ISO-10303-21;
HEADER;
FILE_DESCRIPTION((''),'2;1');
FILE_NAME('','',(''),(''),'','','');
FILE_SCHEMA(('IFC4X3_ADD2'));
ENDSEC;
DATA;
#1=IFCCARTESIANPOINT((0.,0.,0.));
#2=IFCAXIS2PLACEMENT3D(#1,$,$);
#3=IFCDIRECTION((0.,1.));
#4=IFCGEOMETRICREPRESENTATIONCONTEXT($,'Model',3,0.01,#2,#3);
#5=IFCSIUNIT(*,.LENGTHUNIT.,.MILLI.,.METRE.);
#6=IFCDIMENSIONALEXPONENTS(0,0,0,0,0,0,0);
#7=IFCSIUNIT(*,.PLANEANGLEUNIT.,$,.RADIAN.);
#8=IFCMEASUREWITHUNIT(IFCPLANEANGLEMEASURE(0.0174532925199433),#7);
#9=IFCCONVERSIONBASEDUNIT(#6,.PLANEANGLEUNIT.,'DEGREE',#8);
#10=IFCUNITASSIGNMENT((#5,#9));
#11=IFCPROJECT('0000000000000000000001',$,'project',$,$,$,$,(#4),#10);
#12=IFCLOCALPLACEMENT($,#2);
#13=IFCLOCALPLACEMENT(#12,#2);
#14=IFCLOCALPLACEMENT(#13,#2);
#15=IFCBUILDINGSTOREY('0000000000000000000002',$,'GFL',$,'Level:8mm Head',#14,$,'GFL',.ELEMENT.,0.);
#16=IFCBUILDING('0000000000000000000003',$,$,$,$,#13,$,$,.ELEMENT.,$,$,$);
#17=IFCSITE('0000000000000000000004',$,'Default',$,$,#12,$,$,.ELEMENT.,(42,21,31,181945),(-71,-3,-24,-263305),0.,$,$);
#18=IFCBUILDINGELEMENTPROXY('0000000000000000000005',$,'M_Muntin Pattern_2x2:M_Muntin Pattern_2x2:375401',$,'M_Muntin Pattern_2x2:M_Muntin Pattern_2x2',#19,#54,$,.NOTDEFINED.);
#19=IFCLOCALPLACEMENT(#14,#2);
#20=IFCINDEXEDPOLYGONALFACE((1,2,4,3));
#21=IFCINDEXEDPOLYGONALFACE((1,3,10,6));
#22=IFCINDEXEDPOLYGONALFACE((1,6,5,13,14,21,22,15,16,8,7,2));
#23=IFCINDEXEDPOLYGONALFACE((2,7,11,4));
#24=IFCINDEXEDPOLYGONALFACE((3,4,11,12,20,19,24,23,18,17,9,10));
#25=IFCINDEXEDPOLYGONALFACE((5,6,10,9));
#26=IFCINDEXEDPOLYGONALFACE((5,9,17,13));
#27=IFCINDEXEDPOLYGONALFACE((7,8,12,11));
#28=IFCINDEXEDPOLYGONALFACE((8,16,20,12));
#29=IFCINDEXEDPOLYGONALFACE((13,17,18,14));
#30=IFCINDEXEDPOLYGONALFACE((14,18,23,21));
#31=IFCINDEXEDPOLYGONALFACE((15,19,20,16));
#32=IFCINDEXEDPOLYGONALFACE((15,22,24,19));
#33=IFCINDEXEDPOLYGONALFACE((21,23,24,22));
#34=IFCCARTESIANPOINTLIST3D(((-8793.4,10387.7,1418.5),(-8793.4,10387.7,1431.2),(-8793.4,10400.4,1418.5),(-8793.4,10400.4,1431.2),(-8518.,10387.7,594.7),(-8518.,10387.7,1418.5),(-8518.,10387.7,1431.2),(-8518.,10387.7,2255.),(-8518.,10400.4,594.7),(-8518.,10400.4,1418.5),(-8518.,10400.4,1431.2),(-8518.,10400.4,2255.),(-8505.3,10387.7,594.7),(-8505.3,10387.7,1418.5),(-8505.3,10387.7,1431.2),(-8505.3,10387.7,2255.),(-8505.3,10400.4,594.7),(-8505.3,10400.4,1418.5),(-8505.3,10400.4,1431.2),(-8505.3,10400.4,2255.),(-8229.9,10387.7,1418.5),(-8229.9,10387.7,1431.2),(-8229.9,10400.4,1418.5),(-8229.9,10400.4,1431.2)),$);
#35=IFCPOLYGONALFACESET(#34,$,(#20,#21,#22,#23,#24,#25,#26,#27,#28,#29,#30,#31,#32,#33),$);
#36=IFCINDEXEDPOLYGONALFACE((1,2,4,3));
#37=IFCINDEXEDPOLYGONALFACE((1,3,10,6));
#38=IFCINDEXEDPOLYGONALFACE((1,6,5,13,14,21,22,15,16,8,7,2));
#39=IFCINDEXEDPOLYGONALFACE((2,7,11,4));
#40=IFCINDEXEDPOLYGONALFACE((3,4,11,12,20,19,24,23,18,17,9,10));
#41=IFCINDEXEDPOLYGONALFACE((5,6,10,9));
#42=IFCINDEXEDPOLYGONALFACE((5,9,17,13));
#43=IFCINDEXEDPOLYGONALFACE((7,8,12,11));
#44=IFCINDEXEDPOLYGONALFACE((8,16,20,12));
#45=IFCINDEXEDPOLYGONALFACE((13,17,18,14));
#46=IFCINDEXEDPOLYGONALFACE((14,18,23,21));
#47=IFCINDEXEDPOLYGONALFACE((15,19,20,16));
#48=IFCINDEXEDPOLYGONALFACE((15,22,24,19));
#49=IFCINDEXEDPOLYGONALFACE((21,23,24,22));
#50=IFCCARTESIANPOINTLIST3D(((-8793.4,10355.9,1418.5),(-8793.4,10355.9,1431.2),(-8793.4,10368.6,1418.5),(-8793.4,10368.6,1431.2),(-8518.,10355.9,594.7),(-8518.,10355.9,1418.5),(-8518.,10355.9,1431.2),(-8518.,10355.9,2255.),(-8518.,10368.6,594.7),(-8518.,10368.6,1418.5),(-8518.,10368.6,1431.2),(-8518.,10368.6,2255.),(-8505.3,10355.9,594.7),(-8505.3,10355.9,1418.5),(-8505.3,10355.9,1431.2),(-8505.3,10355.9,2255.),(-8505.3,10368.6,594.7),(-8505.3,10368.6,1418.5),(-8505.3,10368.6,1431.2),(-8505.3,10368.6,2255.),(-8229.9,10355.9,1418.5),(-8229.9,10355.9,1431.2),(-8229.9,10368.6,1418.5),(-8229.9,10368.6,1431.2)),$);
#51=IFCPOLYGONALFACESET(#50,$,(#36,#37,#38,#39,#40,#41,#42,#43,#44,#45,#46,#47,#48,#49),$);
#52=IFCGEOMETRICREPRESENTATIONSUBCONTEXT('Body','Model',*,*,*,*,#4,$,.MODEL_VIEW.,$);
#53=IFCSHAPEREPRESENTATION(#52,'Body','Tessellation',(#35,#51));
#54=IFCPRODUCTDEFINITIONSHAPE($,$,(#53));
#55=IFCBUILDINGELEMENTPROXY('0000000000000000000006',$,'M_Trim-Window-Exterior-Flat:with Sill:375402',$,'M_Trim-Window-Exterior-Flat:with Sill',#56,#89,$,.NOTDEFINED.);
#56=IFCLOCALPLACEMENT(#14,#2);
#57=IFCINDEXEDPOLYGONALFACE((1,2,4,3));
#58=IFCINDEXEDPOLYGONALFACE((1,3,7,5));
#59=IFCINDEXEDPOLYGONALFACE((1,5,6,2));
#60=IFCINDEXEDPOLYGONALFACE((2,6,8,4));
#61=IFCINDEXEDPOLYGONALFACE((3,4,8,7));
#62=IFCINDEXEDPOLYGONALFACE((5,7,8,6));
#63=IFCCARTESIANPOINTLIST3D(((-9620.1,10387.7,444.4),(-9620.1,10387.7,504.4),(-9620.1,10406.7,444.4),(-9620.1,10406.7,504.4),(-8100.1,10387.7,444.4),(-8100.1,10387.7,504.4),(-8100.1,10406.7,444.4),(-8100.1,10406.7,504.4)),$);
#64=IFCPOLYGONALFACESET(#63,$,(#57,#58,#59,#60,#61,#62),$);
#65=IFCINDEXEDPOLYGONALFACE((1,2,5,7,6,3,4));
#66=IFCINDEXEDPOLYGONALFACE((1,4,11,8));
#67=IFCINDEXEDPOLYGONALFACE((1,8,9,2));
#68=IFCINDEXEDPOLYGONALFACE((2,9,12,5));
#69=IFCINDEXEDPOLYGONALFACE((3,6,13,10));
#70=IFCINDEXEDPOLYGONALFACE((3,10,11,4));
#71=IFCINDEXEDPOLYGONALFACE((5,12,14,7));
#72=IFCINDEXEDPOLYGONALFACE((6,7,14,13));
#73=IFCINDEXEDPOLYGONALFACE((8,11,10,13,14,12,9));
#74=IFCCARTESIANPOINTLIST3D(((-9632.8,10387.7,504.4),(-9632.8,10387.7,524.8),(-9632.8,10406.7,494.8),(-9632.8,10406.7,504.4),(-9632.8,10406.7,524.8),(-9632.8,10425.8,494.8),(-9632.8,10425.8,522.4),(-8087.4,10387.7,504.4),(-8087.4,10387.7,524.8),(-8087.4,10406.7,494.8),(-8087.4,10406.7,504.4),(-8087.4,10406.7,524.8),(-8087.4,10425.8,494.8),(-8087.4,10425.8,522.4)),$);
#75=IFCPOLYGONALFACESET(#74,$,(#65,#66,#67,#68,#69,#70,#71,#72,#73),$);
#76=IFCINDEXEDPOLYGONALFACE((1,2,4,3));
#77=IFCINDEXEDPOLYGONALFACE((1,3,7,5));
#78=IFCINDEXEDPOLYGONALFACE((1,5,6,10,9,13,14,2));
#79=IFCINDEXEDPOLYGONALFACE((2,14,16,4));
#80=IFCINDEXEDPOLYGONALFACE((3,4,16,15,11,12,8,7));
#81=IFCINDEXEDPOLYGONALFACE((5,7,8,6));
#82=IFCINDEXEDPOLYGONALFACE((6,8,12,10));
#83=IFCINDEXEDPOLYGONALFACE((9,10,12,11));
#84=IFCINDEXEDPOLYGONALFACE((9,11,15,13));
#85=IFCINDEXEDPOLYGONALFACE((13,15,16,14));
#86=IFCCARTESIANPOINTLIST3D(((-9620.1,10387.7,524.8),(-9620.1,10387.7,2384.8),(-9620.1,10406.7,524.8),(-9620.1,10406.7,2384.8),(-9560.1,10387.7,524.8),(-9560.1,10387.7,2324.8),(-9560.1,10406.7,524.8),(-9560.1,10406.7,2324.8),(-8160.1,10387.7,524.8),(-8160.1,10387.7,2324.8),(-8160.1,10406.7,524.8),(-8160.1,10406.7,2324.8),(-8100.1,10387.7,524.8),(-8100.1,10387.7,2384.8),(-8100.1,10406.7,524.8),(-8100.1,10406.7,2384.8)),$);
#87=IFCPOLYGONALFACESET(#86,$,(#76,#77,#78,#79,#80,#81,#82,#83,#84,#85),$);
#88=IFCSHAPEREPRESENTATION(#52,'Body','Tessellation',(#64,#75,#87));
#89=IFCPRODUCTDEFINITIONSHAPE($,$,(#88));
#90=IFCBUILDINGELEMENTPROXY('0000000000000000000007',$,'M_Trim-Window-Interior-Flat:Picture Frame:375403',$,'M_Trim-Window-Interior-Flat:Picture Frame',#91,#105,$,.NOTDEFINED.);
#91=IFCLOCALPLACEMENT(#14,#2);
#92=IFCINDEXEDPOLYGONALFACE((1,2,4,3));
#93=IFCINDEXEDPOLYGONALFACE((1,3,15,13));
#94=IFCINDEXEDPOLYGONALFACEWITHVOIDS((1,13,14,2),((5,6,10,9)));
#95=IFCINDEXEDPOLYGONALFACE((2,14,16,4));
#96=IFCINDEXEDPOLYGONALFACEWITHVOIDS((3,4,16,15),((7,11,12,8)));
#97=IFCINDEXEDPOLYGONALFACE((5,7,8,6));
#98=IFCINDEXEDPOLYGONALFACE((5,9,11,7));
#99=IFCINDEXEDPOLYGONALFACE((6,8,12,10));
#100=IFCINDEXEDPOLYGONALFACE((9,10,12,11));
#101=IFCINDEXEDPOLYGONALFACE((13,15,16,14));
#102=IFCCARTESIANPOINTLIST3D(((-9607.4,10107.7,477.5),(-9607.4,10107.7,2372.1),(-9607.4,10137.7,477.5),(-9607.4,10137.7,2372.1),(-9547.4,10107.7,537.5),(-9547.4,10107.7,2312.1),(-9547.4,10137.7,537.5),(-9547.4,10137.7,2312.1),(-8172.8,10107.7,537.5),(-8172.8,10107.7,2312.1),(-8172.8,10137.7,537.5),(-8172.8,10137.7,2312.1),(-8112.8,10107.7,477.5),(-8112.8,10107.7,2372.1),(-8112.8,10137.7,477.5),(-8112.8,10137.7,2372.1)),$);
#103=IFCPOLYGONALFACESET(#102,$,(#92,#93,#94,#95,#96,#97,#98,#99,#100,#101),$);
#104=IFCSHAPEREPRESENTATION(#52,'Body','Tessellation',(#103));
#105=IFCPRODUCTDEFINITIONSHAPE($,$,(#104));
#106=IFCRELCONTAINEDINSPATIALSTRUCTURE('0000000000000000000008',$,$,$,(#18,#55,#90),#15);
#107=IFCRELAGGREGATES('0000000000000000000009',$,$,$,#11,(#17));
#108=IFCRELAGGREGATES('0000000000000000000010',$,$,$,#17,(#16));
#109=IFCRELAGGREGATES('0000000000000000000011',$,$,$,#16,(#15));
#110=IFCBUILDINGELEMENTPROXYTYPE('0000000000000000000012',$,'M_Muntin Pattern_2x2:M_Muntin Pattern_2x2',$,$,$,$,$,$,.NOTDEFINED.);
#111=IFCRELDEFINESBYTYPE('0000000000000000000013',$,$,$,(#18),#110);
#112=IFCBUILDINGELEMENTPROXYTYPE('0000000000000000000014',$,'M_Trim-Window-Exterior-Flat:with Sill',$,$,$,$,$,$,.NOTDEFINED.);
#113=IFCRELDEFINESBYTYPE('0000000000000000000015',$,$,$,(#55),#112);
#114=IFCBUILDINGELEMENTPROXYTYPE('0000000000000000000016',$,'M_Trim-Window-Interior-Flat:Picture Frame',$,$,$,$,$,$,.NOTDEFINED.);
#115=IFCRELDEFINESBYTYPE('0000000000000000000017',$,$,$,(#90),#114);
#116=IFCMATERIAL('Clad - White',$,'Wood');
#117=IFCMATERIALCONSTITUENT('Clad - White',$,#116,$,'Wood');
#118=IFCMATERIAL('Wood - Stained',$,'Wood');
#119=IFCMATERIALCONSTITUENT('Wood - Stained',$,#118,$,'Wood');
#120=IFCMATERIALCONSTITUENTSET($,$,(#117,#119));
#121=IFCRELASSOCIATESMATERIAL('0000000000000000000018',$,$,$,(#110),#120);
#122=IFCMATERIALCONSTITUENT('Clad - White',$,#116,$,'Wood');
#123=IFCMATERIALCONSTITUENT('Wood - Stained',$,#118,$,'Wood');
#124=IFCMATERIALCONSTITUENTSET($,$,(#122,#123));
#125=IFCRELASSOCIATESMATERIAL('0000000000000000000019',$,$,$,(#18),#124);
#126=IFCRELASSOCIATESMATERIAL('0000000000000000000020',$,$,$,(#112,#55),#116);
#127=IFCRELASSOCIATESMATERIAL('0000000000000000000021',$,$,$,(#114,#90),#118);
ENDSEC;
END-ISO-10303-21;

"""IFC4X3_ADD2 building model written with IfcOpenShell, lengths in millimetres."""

from ifc_helpers import new_model, entity, si_unit, converted_unit, direction, frame, frame_2d, origin, place, context, subcontext, project, spatial, polyline, rectangle, outline, extrude, source, transform, mapped, material, constituent, constituent_set, type_object, type_shapes, element, save


model = new_model("IFC4X3_ADD2")

# Units and contexts
model_context = context("Model", 3, precision=0.01, world=origin(), true_north=direction((0.0, 1.0)))
body_context = subcontext(model_context, "Body", "Model", "MODEL_VIEW")
ifc_project = project(units=[si_unit("LENGTHUNIT", "METRE", prefix="MILLI"), converted_unit("PLANEANGLEUNIT", "DEGREE", entity("IfcPlaneAngleMeasure", 0.0174532925199433), si_unit("PLANEANGLEUNIT", "RADIAN"), dimensions=[0, 0, 0, 0, 0, 0, 0])], contexts=[model_context])

# Site, building, storey
site_placement = place(None, origin())
site = spatial("IfcSite", under=ifc_project, at=site_placement, Name="Default", CompositionType="ELEMENT", RefLatitude=(42, 21, 31, 181945), RefLongitude=(-71, -3, -24, -263305), RefElevation=0.0)
building_placement = place(site_placement, origin())
building = spatial("IfcBuilding", under=site, at=building_placement, CompositionType="ELEMENT")
storey_placement = place(building_placement, origin())
storey = spatial("IfcBuildingStorey", under=building, at=storey_placement, Name="GFL", ObjectType="Level:8mm Head", LongName="GFL", CompositionType="ELEMENT", Elevation=0.0)

# Building element proxies
ifc_material_1 = material(Name="Clad - White", Category="Wood")
ifc_material_2 = material(Name="Wood - Stained", Category="Wood")
ifc_constituent_1 = constituent(ifc_material_1, Name="Clad - White", Category="Wood")
ifc_constituent_2 = constituent(ifc_material_2, Name="Wood - Stained", Category="Wood")
ifc_constituent_set_1 = constituent_set(constituents=[ifc_constituent_1, ifc_constituent_2])
ifc_constituent_3 = constituent(ifc_material_1, Name="Clad - White", Category="Wood")
ifc_constituent_4 = constituent(ifc_material_2, Name="Wood - Stained", Category="Wood")
ifc_constituent_set_2 = constituent_set(constituents=[ifc_constituent_3, ifc_constituent_4])
building_element_proxy_type_1 = type_object("IfcBuildingElementProxyType", Name="M_Muntin Pattern_2x2:M_Muntin Pattern_2x2", PredefinedType="NOTDEFINED", material=ifc_constituent_set_2)
shared_shape_1 = source(origin(), body_context, "Body", "SweptSolid", [
    extrude(outline(polyline([(6.4, -6.4), (830.1, -6.4), (830.1, 6.3), (6.4, 6.3), (6.4, 281.7), (-6.3, 281.7), (-6.3, 6.3), (-830.2, 6.3), (-830.2, -6.4), (-6.3, -6.4), (-6.3, -281.7), (6.4, -281.7), (6.4, -6.4)])), frame((0.0, -22.2, 830.1), z_axis=(0.0, 1.0, 0.0), x_axis=(0.0, 0.0, 1.0)), (0.0, 0.0, 1.0), 12.7),
    extrude(outline(polyline([(6.4, -6.4), (830.2, -6.4), (830.2, 6.3), (6.4, 6.3), (6.4, 281.7), (-6.3, 281.7), (-6.3, 6.3), (-830.2, 6.3), (-830.2, -6.4), (-6.3, -6.4), (-6.3, -281.7), (6.4, -281.7), (6.4, -6.4)])), frame((0.0, 9.5, 830.2), z_axis=(0.0, 1.0, 0.0), x_axis=(0.0, 0.0, 1.0)), (0.0, 0.0, 1.0), 12.7),
])
type_shapes(building_element_proxy_type_1, [shared_shape_1])
proxy_1_placement = place(storey_placement, frame((-8511.7, 10378.2, 594.7), z_axis=(0.0, 0.0, 1.0), x_axis=(-1.0, 0.0, 0.0)))
element("IfcBuildingElementProxy", 1, at=proxy_1_placement, inside=storey, type_object=building_element_proxy_type_1, material=ifc_constituent_set_1, Name="M_Muntin Pattern_2x2:M_Muntin Pattern_2x2:375401", ObjectType="M_Muntin Pattern_2x2:M_Muntin Pattern_2x2", PredefinedType="NOTDEFINED", context=body_context, shape_type="MappedRepresentation", body=[
    mapped(shared_shape_1, transform((0.0, 0.0, 0.0), scale=1.0)),
])
building_element_proxy_type_2 = type_object("IfcBuildingElementProxyType", Name="M_Trim-Window-Exterior-Flat:with Sill", PredefinedType="NOTDEFINED", material=ifc_material_1)
shared_shape_2 = source(origin(), body_context, "Body", "SweptSolid", [
    extrude(rectangle(XDim=1520.0, YDim=60.0, at=frame_2d((0.0, 0.0), x_axis=(1.0, 0.0))), frame((0.0, -1850.4, 0.0), z_axis=(0.0, 0.0, 1.0), x_axis=(-1.0, 0.0, 0.0)), (0.0, 0.0, 1.0), 19.1),
    extrude(outline(polyline([(-19.0, -15.2), (0.0, -15.2), (0.0, -5.7), (19.0, -5.7), (19.0, 14.8), (0.0, 14.8), (-19.0, 12.3), (-19.0, -15.2)])), frame((-772.7, -1814.8, 19.0), z_axis=(1.0, 0.0, 0.0), x_axis=(0.0, 0.0, -1.0)), (0.0, 0.0, 1.0), 1545.4),
    extrude(outline(polyline([(-945.0, -760.0), (915.0, -760.0), (915.0, -700.0), (-885.0, -700.0), (-885.0, 700.0), (915.0, 700.0), (915.0, 760.0), (-945.0, 760.0), (-945.0, -760.0)])), frame((0.0, -885.0, 0.0), z_axis=(0.0, 0.0, 1.0), x_axis=(0.0, -1.0, 0.0)), (0.0, 0.0, 1.0), 19.1),
])
type_shapes(building_element_proxy_type_2, [shared_shape_2])
proxy_2_placement = place(storey_placement, frame((-8860.1, 10387.7, 2324.8), z_axis=(0.0, 1.0, 0.0), x_axis=(-1.0, 0.0, 0.0)))
element("IfcBuildingElementProxy", 2, at=proxy_2_placement, inside=storey, type_object=building_element_proxy_type_2, material=ifc_material_1, Name="M_Trim-Window-Exterior-Flat:with Sill:375402", ObjectType="M_Trim-Window-Exterior-Flat:with Sill", PredefinedType="NOTDEFINED", context=body_context, shape_type="MappedRepresentation", body=[
    mapped(shared_shape_2, transform((0.0, 0.0, 0.0), scale=1.0)),
])
building_element_proxy_type_3 = type_object("IfcBuildingElementProxyType", Name="M_Trim-Window-Interior-Flat:Picture Frame", PredefinedType="NOTDEFINED", material=ifc_material_2)
shared_shape_3 = source(origin(), body_context, "Body", "SweptSolid", [
    extrude(outline(polyline([(-747.3, -947.3), (747.3, -947.3), (747.3, 947.3), (-747.3, 947.3), (-747.3, -947.3)]), holes=[polyline([(-687.3, -887.3), (-687.3, 887.3), (687.3, 887.3), (687.3, -887.3), (-687.3, -887.3)])]), frame((0.0, -900.0, 0.0), z_axis=(0.0, 0.0, 1.0), x_axis=(-1.0, 0.0, 0.0)), (0.0, 0.0, 1.0), 30.0),
])
type_shapes(building_element_proxy_type_3, [shared_shape_3])
proxy_3_placement = place(storey_placement, frame((-8860.1, 10137.7, 2324.8), z_axis=(0.0, -1.0, 0.0), x_axis=(1.0, 0.0, 0.0)))
element("IfcBuildingElementProxy", 3, at=proxy_3_placement, inside=storey, type_object=building_element_proxy_type_3, material=ifc_material_2, Name="M_Trim-Window-Interior-Flat:Picture Frame:375403", ObjectType="M_Trim-Window-Interior-Flat:Picture Frame", PredefinedType="NOTDEFINED", context=body_context, shape_type="MappedRepresentation", body=[
    mapped(shared_shape_3, transform((0.0, 0.0, 0.0), scale=1.0)),
])

save(model, "model.ifc")
